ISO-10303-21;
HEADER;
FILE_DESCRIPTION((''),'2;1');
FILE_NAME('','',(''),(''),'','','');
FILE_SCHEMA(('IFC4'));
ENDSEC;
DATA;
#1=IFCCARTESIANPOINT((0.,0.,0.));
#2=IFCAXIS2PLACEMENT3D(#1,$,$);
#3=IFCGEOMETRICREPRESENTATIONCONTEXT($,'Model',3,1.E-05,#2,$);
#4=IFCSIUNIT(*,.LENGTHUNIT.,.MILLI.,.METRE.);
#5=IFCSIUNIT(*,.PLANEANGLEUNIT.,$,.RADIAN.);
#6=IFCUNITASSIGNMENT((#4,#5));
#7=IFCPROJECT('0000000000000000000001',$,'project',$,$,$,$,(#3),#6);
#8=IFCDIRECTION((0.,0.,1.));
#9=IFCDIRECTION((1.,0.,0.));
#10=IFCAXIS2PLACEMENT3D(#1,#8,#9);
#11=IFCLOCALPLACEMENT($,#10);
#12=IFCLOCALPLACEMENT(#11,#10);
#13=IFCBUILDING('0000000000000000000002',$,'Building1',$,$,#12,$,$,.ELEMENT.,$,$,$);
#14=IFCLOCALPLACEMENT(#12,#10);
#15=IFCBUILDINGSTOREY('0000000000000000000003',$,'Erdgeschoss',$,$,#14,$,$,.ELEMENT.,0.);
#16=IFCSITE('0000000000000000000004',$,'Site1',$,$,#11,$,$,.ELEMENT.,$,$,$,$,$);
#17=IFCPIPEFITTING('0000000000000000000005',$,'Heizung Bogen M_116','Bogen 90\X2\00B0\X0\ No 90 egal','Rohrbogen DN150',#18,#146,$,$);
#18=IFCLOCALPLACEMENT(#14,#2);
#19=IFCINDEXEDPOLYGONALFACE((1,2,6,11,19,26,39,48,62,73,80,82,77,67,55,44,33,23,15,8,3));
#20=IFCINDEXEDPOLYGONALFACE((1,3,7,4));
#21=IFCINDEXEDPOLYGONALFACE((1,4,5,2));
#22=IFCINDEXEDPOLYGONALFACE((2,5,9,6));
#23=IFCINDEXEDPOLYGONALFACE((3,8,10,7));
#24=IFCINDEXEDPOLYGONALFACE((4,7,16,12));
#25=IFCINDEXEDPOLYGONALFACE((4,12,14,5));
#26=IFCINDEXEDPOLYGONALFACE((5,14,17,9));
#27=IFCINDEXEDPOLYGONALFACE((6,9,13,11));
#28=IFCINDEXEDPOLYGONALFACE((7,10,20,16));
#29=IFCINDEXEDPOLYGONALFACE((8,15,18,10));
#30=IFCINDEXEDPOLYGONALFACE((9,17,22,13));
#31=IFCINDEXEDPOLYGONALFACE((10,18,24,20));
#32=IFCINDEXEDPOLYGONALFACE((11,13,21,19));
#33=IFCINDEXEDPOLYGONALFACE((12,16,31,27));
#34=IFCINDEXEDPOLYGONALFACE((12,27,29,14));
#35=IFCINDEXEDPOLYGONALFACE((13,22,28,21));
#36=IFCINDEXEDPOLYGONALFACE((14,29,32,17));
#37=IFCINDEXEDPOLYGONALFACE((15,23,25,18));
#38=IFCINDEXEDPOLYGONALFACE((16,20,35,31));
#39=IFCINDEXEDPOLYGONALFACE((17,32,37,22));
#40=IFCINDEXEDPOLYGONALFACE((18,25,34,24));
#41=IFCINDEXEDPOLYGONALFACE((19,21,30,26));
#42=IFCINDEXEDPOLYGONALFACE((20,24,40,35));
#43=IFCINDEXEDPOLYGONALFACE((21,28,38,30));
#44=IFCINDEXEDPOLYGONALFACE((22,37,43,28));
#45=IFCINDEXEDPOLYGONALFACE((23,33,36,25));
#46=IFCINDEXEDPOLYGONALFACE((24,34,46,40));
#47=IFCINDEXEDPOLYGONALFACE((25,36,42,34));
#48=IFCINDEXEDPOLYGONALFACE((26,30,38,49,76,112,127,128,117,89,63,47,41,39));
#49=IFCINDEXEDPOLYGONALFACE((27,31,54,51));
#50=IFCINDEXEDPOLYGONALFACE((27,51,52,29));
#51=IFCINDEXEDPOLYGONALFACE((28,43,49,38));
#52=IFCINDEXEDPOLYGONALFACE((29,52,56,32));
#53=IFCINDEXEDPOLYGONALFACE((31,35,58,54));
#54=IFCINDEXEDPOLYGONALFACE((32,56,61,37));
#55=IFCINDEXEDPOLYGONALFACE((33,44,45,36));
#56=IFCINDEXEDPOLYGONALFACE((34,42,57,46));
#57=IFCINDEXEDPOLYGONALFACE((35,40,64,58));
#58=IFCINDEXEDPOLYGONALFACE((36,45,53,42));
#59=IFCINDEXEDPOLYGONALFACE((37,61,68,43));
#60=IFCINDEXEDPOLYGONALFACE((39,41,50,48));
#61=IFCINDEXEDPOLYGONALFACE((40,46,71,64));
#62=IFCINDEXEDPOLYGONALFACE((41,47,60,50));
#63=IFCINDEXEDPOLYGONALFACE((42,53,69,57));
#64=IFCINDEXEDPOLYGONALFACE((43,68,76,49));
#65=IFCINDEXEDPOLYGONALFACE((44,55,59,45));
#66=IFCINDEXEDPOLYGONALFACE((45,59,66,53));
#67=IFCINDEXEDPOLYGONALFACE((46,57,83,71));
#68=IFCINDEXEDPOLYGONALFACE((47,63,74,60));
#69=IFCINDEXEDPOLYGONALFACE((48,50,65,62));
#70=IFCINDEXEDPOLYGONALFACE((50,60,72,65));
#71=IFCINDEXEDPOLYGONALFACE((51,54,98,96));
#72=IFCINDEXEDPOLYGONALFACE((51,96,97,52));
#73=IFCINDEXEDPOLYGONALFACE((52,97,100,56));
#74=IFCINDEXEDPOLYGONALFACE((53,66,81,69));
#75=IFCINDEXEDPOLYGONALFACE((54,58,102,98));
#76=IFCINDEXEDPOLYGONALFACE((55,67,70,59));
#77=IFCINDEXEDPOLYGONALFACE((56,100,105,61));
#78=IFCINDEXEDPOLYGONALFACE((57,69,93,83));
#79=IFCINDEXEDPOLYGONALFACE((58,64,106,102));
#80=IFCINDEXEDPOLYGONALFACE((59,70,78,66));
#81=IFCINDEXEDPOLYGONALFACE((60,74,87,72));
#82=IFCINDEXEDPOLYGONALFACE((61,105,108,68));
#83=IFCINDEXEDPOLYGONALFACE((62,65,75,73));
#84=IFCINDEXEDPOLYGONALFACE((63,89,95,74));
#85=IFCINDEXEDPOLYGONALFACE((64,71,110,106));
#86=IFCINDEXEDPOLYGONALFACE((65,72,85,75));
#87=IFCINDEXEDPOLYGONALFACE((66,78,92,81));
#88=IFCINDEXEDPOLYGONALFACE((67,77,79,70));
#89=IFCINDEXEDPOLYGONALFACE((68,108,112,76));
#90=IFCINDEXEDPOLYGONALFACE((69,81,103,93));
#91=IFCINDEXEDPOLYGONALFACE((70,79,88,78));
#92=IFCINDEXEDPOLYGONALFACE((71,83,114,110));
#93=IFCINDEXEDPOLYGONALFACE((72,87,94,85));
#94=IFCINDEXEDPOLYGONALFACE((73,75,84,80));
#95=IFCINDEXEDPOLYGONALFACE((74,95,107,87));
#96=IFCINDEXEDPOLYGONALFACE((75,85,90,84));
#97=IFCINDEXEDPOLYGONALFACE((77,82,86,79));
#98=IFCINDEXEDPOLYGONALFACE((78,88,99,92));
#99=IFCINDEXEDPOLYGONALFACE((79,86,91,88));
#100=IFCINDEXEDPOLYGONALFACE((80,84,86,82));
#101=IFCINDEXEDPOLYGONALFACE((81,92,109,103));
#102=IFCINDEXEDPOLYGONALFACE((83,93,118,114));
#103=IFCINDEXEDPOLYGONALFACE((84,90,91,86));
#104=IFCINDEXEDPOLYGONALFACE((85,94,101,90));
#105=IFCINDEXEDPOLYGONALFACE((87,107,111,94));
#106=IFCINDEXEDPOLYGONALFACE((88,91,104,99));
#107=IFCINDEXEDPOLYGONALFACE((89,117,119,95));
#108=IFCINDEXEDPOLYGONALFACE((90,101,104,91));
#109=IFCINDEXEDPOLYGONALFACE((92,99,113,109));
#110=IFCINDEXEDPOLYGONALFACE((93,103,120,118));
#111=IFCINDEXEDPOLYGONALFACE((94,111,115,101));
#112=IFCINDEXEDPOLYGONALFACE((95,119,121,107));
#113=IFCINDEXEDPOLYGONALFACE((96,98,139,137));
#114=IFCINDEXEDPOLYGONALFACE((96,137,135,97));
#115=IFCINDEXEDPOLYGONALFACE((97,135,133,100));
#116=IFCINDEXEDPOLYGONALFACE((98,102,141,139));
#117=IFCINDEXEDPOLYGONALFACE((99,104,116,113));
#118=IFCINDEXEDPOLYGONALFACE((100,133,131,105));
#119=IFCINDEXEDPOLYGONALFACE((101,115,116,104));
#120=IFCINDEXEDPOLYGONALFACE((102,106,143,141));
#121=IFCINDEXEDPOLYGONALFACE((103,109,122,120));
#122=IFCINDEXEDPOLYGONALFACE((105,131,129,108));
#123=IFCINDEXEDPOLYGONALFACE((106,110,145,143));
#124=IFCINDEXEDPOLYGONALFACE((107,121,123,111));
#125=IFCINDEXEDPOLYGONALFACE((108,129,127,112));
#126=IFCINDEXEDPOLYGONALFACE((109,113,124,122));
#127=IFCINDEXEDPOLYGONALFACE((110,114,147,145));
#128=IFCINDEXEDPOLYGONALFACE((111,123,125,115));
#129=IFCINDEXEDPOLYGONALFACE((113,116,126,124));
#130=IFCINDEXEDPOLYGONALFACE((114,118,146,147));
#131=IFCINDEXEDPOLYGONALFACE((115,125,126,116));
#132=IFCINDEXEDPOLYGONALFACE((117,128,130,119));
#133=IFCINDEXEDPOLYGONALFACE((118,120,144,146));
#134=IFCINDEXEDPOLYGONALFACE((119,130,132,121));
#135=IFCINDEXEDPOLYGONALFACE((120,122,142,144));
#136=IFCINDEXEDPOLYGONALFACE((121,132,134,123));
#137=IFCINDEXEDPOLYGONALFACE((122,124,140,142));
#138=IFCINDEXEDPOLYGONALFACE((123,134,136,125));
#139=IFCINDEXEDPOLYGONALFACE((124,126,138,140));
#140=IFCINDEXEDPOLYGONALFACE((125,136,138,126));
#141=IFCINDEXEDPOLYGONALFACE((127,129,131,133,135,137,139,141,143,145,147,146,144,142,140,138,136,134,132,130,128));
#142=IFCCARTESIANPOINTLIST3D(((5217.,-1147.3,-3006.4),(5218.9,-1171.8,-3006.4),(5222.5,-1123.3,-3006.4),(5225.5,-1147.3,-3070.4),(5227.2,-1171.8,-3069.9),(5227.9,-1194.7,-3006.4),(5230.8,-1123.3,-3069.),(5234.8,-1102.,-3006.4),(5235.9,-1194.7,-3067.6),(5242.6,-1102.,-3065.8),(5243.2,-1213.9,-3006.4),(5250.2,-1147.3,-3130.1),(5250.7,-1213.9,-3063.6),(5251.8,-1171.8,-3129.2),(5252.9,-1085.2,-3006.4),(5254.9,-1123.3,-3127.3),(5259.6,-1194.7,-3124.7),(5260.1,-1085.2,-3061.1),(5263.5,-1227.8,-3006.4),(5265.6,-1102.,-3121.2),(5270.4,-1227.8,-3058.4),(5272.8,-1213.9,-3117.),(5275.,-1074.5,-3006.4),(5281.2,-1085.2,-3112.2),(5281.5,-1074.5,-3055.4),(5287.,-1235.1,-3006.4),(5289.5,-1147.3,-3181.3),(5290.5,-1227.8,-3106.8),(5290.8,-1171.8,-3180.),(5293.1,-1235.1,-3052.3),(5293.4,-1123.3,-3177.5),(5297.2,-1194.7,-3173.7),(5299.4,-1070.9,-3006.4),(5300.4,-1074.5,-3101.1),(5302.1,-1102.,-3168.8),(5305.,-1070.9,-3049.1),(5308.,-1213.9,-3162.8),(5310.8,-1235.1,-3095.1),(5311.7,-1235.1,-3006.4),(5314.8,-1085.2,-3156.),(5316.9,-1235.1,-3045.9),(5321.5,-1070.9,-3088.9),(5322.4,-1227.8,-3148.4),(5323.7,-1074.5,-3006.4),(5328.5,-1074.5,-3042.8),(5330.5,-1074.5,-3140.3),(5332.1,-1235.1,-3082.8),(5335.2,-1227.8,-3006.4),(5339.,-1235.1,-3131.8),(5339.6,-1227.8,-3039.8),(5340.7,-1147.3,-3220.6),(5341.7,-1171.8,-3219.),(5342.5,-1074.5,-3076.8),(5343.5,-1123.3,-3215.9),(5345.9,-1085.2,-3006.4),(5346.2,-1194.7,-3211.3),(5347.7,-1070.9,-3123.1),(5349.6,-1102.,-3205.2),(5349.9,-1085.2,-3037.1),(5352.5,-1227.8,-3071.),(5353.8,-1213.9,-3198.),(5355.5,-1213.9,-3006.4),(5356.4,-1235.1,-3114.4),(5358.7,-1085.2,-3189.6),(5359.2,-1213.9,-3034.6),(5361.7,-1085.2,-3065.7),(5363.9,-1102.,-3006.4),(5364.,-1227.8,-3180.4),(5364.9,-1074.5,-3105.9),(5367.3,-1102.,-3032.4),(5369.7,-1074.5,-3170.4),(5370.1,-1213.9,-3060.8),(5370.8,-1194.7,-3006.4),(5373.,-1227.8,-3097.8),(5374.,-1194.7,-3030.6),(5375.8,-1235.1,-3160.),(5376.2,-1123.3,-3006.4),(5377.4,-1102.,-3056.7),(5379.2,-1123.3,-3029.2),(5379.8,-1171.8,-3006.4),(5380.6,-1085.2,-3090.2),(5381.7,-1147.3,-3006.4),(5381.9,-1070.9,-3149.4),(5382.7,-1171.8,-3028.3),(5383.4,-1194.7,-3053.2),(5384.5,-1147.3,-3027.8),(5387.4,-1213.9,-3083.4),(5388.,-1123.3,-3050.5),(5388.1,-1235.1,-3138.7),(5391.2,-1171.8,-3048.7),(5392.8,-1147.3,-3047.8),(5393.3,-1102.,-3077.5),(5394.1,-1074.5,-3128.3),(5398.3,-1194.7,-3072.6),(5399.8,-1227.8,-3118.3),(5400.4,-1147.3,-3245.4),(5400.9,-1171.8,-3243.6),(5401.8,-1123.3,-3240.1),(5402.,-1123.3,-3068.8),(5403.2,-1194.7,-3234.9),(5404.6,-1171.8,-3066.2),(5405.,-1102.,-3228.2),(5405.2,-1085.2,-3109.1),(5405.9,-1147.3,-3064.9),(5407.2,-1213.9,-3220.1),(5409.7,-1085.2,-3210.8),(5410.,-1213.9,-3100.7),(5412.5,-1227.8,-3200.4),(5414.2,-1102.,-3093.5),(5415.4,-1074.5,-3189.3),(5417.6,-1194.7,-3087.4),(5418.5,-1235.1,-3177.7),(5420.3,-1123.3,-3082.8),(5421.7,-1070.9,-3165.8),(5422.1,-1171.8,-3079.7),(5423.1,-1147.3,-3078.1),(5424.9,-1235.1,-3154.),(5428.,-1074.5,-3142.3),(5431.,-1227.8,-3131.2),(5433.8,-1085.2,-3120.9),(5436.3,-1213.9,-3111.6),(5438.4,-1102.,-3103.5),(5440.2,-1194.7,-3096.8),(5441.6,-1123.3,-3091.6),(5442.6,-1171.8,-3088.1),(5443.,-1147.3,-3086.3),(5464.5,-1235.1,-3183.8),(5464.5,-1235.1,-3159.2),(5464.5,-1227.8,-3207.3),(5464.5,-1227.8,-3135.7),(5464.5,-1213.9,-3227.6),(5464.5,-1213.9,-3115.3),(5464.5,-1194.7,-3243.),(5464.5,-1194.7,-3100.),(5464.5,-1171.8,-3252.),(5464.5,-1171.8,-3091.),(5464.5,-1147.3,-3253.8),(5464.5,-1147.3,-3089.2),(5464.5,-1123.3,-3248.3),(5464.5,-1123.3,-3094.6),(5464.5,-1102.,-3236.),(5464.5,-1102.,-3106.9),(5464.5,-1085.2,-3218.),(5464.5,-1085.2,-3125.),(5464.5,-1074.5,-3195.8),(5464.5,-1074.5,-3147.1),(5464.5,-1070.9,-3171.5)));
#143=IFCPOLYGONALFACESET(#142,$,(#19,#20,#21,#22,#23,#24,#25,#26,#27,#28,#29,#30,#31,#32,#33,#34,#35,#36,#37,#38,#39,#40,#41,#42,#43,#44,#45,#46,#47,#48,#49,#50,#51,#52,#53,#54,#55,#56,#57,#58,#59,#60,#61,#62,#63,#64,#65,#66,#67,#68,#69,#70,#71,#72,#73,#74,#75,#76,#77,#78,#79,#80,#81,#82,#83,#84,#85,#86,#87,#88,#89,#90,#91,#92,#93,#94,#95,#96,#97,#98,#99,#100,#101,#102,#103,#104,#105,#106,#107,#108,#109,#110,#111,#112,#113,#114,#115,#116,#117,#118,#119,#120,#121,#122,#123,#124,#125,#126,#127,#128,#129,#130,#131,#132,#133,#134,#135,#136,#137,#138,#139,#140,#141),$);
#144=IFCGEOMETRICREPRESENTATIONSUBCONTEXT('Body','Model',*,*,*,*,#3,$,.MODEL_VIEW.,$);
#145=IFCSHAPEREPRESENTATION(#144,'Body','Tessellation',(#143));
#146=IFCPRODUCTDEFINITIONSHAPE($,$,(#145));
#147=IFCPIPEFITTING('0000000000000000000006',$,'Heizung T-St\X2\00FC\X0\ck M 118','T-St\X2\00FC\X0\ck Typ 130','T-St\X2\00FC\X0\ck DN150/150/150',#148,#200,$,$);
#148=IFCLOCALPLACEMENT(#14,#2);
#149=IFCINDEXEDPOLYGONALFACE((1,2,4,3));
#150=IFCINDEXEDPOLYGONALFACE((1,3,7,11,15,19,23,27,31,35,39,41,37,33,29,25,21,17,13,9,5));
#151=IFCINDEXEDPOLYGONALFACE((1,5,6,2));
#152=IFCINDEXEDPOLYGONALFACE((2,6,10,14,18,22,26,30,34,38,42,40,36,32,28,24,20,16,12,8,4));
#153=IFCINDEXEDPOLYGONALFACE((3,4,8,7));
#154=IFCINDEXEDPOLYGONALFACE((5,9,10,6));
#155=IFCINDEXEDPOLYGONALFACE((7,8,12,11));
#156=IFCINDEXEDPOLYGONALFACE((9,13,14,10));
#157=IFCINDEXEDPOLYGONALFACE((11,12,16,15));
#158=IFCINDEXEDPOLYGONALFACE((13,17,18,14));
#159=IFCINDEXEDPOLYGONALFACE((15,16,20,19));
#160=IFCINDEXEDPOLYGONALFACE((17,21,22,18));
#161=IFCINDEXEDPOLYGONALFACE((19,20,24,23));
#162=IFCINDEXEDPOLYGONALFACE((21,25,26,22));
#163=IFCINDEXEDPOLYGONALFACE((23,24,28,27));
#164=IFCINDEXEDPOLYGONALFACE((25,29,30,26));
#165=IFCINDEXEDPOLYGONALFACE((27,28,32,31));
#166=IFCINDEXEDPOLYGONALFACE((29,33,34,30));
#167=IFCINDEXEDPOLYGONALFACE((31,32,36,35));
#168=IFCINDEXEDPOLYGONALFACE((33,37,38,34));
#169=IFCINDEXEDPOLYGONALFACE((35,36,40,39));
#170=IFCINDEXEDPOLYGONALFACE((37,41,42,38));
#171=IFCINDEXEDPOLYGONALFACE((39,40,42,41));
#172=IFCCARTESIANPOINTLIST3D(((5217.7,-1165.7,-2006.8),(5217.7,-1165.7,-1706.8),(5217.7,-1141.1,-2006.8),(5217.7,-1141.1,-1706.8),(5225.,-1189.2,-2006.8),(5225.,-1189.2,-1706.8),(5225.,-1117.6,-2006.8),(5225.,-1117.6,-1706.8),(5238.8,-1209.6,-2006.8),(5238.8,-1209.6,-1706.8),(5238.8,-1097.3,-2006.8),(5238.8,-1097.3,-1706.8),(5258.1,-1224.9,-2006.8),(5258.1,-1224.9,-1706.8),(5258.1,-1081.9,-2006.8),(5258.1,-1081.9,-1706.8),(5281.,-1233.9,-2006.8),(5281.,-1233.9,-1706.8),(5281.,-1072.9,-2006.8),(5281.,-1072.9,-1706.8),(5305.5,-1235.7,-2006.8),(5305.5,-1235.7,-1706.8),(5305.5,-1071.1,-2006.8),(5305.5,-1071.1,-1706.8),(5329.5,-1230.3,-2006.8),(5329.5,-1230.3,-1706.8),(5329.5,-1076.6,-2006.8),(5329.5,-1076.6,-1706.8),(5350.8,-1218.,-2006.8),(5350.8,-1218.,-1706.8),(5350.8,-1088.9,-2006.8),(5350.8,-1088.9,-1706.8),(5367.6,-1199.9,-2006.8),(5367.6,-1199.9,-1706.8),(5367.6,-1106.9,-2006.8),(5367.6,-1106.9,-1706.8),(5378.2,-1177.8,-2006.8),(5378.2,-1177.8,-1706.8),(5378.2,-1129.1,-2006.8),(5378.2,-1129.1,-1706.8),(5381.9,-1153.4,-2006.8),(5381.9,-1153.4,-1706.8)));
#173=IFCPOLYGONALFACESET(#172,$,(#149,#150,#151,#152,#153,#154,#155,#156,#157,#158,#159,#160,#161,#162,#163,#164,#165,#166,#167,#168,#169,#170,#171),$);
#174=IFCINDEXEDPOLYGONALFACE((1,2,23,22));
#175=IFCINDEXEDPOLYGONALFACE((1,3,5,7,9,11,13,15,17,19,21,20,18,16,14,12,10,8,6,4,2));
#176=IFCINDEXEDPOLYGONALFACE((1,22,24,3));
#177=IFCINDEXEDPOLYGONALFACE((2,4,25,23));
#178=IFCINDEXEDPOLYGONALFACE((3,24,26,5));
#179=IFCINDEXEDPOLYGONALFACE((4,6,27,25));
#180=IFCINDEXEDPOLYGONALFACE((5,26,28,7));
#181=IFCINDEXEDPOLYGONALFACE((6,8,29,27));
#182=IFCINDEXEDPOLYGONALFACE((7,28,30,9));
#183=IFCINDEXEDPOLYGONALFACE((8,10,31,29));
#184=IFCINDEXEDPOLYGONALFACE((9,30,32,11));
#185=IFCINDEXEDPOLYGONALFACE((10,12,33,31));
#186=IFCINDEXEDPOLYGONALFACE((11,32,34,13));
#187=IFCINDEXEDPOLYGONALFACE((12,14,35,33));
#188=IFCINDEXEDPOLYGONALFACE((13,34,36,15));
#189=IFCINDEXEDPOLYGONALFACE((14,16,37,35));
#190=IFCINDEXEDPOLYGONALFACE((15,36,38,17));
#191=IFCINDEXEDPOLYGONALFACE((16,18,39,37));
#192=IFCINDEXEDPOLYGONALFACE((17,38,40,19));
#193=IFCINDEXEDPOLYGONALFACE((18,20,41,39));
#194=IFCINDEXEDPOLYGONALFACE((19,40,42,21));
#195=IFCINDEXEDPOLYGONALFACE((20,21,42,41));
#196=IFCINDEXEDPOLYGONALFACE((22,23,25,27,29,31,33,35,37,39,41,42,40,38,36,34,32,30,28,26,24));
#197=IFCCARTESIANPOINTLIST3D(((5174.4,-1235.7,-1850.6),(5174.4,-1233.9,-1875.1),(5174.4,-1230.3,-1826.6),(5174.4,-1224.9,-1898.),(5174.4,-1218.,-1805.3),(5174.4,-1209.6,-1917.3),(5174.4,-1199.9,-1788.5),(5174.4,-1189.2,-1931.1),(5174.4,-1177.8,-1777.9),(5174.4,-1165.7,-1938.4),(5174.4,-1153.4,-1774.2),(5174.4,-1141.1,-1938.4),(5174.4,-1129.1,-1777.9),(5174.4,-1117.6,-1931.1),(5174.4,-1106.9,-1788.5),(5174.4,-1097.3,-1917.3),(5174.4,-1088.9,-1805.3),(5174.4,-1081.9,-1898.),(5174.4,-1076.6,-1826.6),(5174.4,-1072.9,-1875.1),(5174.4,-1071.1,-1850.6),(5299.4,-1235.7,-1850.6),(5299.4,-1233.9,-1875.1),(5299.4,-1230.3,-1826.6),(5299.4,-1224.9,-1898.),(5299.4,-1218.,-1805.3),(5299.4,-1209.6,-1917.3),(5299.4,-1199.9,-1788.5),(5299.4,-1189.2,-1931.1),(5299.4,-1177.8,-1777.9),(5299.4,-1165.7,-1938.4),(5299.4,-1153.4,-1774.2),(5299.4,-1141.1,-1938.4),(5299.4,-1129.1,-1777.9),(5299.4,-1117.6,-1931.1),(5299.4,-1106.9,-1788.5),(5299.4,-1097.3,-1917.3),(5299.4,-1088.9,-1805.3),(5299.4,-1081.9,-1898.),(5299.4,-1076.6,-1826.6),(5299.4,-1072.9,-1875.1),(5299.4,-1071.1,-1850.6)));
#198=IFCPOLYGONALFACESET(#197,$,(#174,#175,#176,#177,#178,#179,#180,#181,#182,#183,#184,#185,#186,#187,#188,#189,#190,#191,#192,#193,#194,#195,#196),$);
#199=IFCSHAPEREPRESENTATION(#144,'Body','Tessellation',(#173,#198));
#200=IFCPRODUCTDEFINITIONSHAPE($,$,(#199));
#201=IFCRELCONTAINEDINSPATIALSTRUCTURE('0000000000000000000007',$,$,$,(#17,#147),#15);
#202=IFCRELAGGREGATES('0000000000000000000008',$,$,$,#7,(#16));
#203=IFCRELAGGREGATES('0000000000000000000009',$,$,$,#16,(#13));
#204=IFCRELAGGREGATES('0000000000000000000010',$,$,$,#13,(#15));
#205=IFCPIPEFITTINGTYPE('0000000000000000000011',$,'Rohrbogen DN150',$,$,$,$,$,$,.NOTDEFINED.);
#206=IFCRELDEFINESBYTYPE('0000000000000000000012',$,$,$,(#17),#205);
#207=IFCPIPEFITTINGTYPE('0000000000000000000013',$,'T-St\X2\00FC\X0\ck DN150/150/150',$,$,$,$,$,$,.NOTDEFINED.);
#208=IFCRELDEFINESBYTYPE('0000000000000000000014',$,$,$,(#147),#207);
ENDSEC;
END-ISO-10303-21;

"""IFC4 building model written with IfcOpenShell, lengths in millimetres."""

from ifc_helpers import new_model, entity, si_unit, frame, origin, origin_with_axes, origin_2d_with_axis, place, context, subcontext, project, spatial, circle, extrude, source, transform, mapped, type_object, element, save


model = new_model("IFC4")

# Units and contexts
model_context = context("Model", 3, precision=1e-05, world=origin())
body_context = subcontext(model_context, "Body", "Model", "MODEL_VIEW")
ifc_project = project(units=[si_unit("LENGTHUNIT", "METRE", prefix="MILLI"), si_unit("PLANEANGLEUNIT", "RADIAN")], contexts=[model_context])

# Site, building, storey
site_placement = place(None, origin_with_axes())
site = spatial("IfcSite", under=ifc_project, at=site_placement, Name="Site1", CompositionType="ELEMENT")
building_placement = place(site_placement, origin_with_axes())
building = spatial("IfcBuilding", under=site, at=building_placement, Name="Building1", CompositionType="ELEMENT")
storey_placement = place(building_placement, origin_with_axes())
storey = spatial("IfcBuildingStorey", under=building, at=storey_placement, Name="Erdgeschoss", CompositionType="ELEMENT", Elevation=0.0)

# Pipe fittings
pipe_fitting_type_1 = type_object("IfcPipeFittingType", Name="Rohrbogen DN150", PredefinedType="NOTDEFINED")
shared_shape_1 = source(origin_with_axes(), body_context, "Body", "SolidModel", [
    entity("IfcRevolvedAreaSolid", entity("IfcCircleProfileDef", "AREA", None, entity("IfcAxis2Placement2D", entity("IfcCartesianPoint", [0.0, 0.0]), entity("IfcDirection", [1.0, 0.0])), 82.5), entity("IfcAxis2Placement3D", entity("IfcCartesianPoint", [123.8, -41.3, 0.0]), entity("IfcDirection", [-1.0, 0.0, 0.0]), entity("IfcDirection", [0.0, 0.0, 1.0])), entity("IfcAxis1Placement", entity("IfcCartesianPoint", [0.0, 165.1, 0.0]), entity("IfcDirection", [-1.0, 0.0, 0.0])), 1.570796),
])
pipe_fitting_1_placement = place(storey_placement, frame((5340.6, -1153.4, -3130.2), z_axis=(0.0, 0.0, 1.0), x_axis=(1.0, 0.0, 0.0)))
element("IfcPipeFitting", 1, at=pipe_fitting_1_placement, inside=storey, type_object=pipe_fitting_type_1, Name="Heizung Bogen M_116", Description="Bogen 90° No 90 egal", ObjectType="Rohrbogen DN150", context=body_context, shape_type="MappedRepresentation", body=[
    mapped(shared_shape_1, transform((0.0, 0.0, 0.0), x_axis=(0.0, 0.0, 1.0), y_axis=(1.0, 0.0, 0.0), z_axis=(0.0, 1.0, 0.0), scale=1.0)),
])
pipe_fitting_type_2 = type_object("IfcPipeFittingType", Name="T-Stück DN150/150/150", PredefinedType="NOTDEFINED")
pipe_fitting_2_placement = place(storey_placement, frame((5277.8, -1153.4, -1856.8), z_axis=(0.0, 0.0, 1.0), x_axis=(1.0, 0.0, 0.0)))
element("IfcPipeFitting", 2, at=pipe_fitting_2_placement, inside=storey, type_object=pipe_fitting_type_2, Name="Heizung T-Stück M 118", Description="T-Stück Typ 130", ObjectType="T-Stück DN150/150/150", context=body_context, shape_type="SolidModel", body=[
    extrude(circle(Radius=82.5, at=origin_2d_with_axis()), frame((21.6, 0.0, 150.0), z_axis=(0.0, 0.0, -1.0), x_axis=(1.0, 0.0, 0.0)), (0.0, 0.0, 1.0), 300.0),
    extrude(circle(Radius=82.5, at=origin_2d_with_axis()), frame((21.6, 0.0, 0.0), z_axis=(-1.0, 0.0, 0.0), x_axis=(0.0, 0.0, 1.0)), (0.0, 0.0, 1.0), 125.0),
])

save(model, "model.ifc")
